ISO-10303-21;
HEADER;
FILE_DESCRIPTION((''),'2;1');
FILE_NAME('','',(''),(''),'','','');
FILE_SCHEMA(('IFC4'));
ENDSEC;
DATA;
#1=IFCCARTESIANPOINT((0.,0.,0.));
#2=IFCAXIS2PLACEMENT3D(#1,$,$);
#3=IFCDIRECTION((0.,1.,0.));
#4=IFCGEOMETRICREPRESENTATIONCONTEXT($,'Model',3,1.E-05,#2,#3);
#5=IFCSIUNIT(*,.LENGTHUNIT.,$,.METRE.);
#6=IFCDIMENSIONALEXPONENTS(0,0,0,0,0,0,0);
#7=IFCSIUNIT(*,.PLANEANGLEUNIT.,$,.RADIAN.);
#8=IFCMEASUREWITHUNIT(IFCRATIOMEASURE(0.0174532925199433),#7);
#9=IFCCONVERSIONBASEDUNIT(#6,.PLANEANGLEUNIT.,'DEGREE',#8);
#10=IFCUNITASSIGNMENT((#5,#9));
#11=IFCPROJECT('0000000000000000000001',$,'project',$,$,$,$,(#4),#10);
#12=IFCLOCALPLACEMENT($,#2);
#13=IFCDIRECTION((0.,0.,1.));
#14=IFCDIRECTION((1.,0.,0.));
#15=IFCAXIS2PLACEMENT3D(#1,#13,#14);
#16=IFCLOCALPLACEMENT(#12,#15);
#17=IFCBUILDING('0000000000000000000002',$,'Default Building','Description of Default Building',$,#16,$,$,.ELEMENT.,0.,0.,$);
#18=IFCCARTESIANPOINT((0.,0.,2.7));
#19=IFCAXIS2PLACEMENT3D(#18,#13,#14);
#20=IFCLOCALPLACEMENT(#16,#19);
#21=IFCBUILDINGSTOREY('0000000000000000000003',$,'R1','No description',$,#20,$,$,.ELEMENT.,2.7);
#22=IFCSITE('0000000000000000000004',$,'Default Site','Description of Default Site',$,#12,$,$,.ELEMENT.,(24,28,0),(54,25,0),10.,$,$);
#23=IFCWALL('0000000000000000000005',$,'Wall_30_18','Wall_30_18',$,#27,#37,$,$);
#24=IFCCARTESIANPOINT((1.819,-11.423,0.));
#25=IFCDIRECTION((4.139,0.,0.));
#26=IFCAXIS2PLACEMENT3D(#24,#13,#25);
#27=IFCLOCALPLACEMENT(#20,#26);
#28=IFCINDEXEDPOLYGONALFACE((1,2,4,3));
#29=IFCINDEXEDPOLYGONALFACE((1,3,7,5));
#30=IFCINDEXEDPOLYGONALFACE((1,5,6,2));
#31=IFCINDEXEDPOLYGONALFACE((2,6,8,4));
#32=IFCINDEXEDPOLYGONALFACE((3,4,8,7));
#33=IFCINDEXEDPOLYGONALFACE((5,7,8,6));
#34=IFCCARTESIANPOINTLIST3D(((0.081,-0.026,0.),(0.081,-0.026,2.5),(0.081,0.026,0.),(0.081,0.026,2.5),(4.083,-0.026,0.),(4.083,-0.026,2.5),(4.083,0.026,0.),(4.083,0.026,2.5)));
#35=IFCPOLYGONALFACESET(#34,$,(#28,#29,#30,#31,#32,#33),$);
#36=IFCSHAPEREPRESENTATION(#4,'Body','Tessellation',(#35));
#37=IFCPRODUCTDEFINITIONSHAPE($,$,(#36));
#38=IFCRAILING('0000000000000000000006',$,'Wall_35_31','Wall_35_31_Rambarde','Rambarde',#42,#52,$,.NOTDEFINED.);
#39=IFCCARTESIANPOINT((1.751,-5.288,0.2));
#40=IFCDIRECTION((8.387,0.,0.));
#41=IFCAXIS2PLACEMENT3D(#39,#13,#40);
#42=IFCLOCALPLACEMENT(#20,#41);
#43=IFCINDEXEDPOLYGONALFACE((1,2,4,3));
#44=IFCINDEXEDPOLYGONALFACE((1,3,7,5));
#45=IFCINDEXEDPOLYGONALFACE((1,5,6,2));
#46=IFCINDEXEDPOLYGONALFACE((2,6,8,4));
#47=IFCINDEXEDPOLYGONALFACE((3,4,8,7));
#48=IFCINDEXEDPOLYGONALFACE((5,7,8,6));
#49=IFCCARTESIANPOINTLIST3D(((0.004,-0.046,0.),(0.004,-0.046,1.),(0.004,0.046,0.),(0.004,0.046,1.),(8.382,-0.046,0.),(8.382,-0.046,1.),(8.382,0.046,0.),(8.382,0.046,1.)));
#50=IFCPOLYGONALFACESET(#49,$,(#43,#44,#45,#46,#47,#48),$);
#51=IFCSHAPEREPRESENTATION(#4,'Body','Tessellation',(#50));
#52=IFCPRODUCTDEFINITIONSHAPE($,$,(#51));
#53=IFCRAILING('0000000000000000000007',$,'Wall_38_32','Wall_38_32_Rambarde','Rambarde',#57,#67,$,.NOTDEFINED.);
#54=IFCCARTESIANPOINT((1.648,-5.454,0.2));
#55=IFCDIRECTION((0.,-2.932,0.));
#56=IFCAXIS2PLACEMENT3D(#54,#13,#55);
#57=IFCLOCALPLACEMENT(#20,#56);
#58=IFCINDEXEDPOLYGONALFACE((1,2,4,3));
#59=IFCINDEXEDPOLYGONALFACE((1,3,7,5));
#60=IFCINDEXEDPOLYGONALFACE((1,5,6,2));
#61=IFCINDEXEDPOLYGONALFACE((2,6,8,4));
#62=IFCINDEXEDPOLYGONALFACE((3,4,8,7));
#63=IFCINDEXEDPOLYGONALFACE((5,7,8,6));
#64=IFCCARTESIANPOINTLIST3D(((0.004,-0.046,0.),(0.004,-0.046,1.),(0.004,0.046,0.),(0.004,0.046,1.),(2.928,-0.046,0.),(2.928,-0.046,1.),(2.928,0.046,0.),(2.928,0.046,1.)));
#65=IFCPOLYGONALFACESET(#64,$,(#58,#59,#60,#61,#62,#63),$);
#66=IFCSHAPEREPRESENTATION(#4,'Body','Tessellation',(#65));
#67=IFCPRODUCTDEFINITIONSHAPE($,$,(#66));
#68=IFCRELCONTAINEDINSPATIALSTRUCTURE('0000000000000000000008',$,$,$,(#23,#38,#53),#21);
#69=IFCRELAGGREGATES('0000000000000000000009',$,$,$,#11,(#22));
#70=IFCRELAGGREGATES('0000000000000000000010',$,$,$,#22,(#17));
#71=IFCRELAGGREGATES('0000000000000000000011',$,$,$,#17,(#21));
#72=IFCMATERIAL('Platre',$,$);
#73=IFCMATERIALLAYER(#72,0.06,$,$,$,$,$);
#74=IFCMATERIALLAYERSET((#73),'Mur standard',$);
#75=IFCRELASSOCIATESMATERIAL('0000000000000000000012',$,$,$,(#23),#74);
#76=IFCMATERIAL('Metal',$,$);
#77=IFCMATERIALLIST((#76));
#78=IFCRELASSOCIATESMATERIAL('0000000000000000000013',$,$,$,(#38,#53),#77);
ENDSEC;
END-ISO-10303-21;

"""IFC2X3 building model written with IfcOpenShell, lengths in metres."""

from ifc_helpers import new_model, entity, si_unit, converted_unit, direction, frame, origin, origin_with_axes, place, context, project, spatial, polyline, outline, extrude, material, material_list, layer, layer_set, layer_usage, element, save


model = new_model("IFC2X3")

# Units and contexts
model_context = context("Model", 3, precision=1e-05, world=origin(), true_north=direction((0.0, 1.0, 0.0)))
ifc_project = project(units=[si_unit("LENGTHUNIT", "METRE"), converted_unit("PLANEANGLEUNIT", "DEGREE", entity("IfcRatioMeasure", 0.0174532925199433), si_unit("PLANEANGLEUNIT", "RADIAN"), dimensions=[0, 0, 0, 0, 0, 0, 0])], contexts=[model_context])

# Site, building, storey
site_placement = place(None, origin())
site = spatial("IfcSite", under=ifc_project, at=site_placement, Name="Default Site", Description="Description of Default Site", CompositionType="ELEMENT", RefLatitude=(24, 28, 0), RefLongitude=(54, 25, 0), RefElevation=10.0)
building_placement = place(site_placement, origin_with_axes())
building = spatial("IfcBuilding", under=site, at=building_placement, Name="Default Building", Description="Description of Default Building", CompositionType="ELEMENT", ElevationOfRefHeight=0.0, ElevationOfTerrain=0.0)
storey_placement = place(building_placement, frame((0.0, 0.0, 2.7), z_axis=(0.0, 0.0, 1.0), x_axis=(1.0, 0.0, 0.0)))
storey = spatial("IfcBuildingStorey", under=building, at=storey_placement, Name="R1", Description="No description", CompositionType="ELEMENT", Elevation=2.7)

# Shared definitions
ifc_material_1 = material(Name="Platre")
ifc_layer_1 = layer(ifc_material_1, 0.06)
ifc_layer_set_1 = layer_set([ifc_layer_1], Name="Mur standard")
ifc_layer_usage_1 = layer_usage(ifc_layer_set_1, "AXIS2", "NEGATIVE", 0.06)

# Wall
wall_1_placement = place(storey_placement, frame((1.819, -11.423, 0.0), z_axis=(0.0, 0.0, 1.0), x_axis=(4.139, 0.0, 0.0)))
element("IfcWall", 1, at=wall_1_placement, inside=storey, material=ifc_layer_usage_1, Name="Wall_30_18", Description="Wall_30_18", context=model_context, shape_type="SweptSolid", body=[
    extrude(outline(polyline([(0.081, 0.026), (0.081, -0.026), (4.083, -0.026), (4.083, 0.026), (0.081, 0.026)])), origin(), (0.0, 0.0, 1.0), 2.5),
])

# Railings
ifc_material_2 = material(Name="Metal")
ifc_material_list_1 = material_list([ifc_material_2])
railing_1_placement = place(storey_placement, frame((1.751, -5.288, 0.2), z_axis=(0.0, 0.0, 1.0), x_axis=(8.387, 0.0, 0.0)))
element("IfcRailing", 2, at=railing_1_placement, inside=storey, material=ifc_material_list_1, Name="Wall_35_31", Description="Wall_35_31_Rambarde", ObjectType="Rambarde", PredefinedType="NOTDEFINED", context=model_context, shape_type="SweptSolid", body=[
    extrude(outline(polyline([(0.004, 0.046), (0.004, -0.046), (8.382, -0.046), (8.382, 0.046), (0.004, 0.046)])), origin(), (0.0, 0.0, 1.0), 1.0),
])
railing_2_placement = place(storey_placement, frame((1.648, -5.454, 0.2), z_axis=(0.0, 0.0, 1.0), x_axis=(0.0, -2.932, 0.0)))
element("IfcRailing", 3, at=railing_2_placement, inside=storey, material=ifc_material_list_1, Name="Wall_38_32", Description="Wall_38_32_Rambarde", ObjectType="Rambarde", PredefinedType="NOTDEFINED", context=model_context, shape_type="SweptSolid", body=[
    extrude(outline(polyline([(0.004, -0.046), (2.928, -0.046), (2.928, 0.046), (0.004, 0.046), (0.004, -0.046)])), origin(), (0.0, 0.0, 1.0), 1.0),
])

save(model, "model.ifc")
